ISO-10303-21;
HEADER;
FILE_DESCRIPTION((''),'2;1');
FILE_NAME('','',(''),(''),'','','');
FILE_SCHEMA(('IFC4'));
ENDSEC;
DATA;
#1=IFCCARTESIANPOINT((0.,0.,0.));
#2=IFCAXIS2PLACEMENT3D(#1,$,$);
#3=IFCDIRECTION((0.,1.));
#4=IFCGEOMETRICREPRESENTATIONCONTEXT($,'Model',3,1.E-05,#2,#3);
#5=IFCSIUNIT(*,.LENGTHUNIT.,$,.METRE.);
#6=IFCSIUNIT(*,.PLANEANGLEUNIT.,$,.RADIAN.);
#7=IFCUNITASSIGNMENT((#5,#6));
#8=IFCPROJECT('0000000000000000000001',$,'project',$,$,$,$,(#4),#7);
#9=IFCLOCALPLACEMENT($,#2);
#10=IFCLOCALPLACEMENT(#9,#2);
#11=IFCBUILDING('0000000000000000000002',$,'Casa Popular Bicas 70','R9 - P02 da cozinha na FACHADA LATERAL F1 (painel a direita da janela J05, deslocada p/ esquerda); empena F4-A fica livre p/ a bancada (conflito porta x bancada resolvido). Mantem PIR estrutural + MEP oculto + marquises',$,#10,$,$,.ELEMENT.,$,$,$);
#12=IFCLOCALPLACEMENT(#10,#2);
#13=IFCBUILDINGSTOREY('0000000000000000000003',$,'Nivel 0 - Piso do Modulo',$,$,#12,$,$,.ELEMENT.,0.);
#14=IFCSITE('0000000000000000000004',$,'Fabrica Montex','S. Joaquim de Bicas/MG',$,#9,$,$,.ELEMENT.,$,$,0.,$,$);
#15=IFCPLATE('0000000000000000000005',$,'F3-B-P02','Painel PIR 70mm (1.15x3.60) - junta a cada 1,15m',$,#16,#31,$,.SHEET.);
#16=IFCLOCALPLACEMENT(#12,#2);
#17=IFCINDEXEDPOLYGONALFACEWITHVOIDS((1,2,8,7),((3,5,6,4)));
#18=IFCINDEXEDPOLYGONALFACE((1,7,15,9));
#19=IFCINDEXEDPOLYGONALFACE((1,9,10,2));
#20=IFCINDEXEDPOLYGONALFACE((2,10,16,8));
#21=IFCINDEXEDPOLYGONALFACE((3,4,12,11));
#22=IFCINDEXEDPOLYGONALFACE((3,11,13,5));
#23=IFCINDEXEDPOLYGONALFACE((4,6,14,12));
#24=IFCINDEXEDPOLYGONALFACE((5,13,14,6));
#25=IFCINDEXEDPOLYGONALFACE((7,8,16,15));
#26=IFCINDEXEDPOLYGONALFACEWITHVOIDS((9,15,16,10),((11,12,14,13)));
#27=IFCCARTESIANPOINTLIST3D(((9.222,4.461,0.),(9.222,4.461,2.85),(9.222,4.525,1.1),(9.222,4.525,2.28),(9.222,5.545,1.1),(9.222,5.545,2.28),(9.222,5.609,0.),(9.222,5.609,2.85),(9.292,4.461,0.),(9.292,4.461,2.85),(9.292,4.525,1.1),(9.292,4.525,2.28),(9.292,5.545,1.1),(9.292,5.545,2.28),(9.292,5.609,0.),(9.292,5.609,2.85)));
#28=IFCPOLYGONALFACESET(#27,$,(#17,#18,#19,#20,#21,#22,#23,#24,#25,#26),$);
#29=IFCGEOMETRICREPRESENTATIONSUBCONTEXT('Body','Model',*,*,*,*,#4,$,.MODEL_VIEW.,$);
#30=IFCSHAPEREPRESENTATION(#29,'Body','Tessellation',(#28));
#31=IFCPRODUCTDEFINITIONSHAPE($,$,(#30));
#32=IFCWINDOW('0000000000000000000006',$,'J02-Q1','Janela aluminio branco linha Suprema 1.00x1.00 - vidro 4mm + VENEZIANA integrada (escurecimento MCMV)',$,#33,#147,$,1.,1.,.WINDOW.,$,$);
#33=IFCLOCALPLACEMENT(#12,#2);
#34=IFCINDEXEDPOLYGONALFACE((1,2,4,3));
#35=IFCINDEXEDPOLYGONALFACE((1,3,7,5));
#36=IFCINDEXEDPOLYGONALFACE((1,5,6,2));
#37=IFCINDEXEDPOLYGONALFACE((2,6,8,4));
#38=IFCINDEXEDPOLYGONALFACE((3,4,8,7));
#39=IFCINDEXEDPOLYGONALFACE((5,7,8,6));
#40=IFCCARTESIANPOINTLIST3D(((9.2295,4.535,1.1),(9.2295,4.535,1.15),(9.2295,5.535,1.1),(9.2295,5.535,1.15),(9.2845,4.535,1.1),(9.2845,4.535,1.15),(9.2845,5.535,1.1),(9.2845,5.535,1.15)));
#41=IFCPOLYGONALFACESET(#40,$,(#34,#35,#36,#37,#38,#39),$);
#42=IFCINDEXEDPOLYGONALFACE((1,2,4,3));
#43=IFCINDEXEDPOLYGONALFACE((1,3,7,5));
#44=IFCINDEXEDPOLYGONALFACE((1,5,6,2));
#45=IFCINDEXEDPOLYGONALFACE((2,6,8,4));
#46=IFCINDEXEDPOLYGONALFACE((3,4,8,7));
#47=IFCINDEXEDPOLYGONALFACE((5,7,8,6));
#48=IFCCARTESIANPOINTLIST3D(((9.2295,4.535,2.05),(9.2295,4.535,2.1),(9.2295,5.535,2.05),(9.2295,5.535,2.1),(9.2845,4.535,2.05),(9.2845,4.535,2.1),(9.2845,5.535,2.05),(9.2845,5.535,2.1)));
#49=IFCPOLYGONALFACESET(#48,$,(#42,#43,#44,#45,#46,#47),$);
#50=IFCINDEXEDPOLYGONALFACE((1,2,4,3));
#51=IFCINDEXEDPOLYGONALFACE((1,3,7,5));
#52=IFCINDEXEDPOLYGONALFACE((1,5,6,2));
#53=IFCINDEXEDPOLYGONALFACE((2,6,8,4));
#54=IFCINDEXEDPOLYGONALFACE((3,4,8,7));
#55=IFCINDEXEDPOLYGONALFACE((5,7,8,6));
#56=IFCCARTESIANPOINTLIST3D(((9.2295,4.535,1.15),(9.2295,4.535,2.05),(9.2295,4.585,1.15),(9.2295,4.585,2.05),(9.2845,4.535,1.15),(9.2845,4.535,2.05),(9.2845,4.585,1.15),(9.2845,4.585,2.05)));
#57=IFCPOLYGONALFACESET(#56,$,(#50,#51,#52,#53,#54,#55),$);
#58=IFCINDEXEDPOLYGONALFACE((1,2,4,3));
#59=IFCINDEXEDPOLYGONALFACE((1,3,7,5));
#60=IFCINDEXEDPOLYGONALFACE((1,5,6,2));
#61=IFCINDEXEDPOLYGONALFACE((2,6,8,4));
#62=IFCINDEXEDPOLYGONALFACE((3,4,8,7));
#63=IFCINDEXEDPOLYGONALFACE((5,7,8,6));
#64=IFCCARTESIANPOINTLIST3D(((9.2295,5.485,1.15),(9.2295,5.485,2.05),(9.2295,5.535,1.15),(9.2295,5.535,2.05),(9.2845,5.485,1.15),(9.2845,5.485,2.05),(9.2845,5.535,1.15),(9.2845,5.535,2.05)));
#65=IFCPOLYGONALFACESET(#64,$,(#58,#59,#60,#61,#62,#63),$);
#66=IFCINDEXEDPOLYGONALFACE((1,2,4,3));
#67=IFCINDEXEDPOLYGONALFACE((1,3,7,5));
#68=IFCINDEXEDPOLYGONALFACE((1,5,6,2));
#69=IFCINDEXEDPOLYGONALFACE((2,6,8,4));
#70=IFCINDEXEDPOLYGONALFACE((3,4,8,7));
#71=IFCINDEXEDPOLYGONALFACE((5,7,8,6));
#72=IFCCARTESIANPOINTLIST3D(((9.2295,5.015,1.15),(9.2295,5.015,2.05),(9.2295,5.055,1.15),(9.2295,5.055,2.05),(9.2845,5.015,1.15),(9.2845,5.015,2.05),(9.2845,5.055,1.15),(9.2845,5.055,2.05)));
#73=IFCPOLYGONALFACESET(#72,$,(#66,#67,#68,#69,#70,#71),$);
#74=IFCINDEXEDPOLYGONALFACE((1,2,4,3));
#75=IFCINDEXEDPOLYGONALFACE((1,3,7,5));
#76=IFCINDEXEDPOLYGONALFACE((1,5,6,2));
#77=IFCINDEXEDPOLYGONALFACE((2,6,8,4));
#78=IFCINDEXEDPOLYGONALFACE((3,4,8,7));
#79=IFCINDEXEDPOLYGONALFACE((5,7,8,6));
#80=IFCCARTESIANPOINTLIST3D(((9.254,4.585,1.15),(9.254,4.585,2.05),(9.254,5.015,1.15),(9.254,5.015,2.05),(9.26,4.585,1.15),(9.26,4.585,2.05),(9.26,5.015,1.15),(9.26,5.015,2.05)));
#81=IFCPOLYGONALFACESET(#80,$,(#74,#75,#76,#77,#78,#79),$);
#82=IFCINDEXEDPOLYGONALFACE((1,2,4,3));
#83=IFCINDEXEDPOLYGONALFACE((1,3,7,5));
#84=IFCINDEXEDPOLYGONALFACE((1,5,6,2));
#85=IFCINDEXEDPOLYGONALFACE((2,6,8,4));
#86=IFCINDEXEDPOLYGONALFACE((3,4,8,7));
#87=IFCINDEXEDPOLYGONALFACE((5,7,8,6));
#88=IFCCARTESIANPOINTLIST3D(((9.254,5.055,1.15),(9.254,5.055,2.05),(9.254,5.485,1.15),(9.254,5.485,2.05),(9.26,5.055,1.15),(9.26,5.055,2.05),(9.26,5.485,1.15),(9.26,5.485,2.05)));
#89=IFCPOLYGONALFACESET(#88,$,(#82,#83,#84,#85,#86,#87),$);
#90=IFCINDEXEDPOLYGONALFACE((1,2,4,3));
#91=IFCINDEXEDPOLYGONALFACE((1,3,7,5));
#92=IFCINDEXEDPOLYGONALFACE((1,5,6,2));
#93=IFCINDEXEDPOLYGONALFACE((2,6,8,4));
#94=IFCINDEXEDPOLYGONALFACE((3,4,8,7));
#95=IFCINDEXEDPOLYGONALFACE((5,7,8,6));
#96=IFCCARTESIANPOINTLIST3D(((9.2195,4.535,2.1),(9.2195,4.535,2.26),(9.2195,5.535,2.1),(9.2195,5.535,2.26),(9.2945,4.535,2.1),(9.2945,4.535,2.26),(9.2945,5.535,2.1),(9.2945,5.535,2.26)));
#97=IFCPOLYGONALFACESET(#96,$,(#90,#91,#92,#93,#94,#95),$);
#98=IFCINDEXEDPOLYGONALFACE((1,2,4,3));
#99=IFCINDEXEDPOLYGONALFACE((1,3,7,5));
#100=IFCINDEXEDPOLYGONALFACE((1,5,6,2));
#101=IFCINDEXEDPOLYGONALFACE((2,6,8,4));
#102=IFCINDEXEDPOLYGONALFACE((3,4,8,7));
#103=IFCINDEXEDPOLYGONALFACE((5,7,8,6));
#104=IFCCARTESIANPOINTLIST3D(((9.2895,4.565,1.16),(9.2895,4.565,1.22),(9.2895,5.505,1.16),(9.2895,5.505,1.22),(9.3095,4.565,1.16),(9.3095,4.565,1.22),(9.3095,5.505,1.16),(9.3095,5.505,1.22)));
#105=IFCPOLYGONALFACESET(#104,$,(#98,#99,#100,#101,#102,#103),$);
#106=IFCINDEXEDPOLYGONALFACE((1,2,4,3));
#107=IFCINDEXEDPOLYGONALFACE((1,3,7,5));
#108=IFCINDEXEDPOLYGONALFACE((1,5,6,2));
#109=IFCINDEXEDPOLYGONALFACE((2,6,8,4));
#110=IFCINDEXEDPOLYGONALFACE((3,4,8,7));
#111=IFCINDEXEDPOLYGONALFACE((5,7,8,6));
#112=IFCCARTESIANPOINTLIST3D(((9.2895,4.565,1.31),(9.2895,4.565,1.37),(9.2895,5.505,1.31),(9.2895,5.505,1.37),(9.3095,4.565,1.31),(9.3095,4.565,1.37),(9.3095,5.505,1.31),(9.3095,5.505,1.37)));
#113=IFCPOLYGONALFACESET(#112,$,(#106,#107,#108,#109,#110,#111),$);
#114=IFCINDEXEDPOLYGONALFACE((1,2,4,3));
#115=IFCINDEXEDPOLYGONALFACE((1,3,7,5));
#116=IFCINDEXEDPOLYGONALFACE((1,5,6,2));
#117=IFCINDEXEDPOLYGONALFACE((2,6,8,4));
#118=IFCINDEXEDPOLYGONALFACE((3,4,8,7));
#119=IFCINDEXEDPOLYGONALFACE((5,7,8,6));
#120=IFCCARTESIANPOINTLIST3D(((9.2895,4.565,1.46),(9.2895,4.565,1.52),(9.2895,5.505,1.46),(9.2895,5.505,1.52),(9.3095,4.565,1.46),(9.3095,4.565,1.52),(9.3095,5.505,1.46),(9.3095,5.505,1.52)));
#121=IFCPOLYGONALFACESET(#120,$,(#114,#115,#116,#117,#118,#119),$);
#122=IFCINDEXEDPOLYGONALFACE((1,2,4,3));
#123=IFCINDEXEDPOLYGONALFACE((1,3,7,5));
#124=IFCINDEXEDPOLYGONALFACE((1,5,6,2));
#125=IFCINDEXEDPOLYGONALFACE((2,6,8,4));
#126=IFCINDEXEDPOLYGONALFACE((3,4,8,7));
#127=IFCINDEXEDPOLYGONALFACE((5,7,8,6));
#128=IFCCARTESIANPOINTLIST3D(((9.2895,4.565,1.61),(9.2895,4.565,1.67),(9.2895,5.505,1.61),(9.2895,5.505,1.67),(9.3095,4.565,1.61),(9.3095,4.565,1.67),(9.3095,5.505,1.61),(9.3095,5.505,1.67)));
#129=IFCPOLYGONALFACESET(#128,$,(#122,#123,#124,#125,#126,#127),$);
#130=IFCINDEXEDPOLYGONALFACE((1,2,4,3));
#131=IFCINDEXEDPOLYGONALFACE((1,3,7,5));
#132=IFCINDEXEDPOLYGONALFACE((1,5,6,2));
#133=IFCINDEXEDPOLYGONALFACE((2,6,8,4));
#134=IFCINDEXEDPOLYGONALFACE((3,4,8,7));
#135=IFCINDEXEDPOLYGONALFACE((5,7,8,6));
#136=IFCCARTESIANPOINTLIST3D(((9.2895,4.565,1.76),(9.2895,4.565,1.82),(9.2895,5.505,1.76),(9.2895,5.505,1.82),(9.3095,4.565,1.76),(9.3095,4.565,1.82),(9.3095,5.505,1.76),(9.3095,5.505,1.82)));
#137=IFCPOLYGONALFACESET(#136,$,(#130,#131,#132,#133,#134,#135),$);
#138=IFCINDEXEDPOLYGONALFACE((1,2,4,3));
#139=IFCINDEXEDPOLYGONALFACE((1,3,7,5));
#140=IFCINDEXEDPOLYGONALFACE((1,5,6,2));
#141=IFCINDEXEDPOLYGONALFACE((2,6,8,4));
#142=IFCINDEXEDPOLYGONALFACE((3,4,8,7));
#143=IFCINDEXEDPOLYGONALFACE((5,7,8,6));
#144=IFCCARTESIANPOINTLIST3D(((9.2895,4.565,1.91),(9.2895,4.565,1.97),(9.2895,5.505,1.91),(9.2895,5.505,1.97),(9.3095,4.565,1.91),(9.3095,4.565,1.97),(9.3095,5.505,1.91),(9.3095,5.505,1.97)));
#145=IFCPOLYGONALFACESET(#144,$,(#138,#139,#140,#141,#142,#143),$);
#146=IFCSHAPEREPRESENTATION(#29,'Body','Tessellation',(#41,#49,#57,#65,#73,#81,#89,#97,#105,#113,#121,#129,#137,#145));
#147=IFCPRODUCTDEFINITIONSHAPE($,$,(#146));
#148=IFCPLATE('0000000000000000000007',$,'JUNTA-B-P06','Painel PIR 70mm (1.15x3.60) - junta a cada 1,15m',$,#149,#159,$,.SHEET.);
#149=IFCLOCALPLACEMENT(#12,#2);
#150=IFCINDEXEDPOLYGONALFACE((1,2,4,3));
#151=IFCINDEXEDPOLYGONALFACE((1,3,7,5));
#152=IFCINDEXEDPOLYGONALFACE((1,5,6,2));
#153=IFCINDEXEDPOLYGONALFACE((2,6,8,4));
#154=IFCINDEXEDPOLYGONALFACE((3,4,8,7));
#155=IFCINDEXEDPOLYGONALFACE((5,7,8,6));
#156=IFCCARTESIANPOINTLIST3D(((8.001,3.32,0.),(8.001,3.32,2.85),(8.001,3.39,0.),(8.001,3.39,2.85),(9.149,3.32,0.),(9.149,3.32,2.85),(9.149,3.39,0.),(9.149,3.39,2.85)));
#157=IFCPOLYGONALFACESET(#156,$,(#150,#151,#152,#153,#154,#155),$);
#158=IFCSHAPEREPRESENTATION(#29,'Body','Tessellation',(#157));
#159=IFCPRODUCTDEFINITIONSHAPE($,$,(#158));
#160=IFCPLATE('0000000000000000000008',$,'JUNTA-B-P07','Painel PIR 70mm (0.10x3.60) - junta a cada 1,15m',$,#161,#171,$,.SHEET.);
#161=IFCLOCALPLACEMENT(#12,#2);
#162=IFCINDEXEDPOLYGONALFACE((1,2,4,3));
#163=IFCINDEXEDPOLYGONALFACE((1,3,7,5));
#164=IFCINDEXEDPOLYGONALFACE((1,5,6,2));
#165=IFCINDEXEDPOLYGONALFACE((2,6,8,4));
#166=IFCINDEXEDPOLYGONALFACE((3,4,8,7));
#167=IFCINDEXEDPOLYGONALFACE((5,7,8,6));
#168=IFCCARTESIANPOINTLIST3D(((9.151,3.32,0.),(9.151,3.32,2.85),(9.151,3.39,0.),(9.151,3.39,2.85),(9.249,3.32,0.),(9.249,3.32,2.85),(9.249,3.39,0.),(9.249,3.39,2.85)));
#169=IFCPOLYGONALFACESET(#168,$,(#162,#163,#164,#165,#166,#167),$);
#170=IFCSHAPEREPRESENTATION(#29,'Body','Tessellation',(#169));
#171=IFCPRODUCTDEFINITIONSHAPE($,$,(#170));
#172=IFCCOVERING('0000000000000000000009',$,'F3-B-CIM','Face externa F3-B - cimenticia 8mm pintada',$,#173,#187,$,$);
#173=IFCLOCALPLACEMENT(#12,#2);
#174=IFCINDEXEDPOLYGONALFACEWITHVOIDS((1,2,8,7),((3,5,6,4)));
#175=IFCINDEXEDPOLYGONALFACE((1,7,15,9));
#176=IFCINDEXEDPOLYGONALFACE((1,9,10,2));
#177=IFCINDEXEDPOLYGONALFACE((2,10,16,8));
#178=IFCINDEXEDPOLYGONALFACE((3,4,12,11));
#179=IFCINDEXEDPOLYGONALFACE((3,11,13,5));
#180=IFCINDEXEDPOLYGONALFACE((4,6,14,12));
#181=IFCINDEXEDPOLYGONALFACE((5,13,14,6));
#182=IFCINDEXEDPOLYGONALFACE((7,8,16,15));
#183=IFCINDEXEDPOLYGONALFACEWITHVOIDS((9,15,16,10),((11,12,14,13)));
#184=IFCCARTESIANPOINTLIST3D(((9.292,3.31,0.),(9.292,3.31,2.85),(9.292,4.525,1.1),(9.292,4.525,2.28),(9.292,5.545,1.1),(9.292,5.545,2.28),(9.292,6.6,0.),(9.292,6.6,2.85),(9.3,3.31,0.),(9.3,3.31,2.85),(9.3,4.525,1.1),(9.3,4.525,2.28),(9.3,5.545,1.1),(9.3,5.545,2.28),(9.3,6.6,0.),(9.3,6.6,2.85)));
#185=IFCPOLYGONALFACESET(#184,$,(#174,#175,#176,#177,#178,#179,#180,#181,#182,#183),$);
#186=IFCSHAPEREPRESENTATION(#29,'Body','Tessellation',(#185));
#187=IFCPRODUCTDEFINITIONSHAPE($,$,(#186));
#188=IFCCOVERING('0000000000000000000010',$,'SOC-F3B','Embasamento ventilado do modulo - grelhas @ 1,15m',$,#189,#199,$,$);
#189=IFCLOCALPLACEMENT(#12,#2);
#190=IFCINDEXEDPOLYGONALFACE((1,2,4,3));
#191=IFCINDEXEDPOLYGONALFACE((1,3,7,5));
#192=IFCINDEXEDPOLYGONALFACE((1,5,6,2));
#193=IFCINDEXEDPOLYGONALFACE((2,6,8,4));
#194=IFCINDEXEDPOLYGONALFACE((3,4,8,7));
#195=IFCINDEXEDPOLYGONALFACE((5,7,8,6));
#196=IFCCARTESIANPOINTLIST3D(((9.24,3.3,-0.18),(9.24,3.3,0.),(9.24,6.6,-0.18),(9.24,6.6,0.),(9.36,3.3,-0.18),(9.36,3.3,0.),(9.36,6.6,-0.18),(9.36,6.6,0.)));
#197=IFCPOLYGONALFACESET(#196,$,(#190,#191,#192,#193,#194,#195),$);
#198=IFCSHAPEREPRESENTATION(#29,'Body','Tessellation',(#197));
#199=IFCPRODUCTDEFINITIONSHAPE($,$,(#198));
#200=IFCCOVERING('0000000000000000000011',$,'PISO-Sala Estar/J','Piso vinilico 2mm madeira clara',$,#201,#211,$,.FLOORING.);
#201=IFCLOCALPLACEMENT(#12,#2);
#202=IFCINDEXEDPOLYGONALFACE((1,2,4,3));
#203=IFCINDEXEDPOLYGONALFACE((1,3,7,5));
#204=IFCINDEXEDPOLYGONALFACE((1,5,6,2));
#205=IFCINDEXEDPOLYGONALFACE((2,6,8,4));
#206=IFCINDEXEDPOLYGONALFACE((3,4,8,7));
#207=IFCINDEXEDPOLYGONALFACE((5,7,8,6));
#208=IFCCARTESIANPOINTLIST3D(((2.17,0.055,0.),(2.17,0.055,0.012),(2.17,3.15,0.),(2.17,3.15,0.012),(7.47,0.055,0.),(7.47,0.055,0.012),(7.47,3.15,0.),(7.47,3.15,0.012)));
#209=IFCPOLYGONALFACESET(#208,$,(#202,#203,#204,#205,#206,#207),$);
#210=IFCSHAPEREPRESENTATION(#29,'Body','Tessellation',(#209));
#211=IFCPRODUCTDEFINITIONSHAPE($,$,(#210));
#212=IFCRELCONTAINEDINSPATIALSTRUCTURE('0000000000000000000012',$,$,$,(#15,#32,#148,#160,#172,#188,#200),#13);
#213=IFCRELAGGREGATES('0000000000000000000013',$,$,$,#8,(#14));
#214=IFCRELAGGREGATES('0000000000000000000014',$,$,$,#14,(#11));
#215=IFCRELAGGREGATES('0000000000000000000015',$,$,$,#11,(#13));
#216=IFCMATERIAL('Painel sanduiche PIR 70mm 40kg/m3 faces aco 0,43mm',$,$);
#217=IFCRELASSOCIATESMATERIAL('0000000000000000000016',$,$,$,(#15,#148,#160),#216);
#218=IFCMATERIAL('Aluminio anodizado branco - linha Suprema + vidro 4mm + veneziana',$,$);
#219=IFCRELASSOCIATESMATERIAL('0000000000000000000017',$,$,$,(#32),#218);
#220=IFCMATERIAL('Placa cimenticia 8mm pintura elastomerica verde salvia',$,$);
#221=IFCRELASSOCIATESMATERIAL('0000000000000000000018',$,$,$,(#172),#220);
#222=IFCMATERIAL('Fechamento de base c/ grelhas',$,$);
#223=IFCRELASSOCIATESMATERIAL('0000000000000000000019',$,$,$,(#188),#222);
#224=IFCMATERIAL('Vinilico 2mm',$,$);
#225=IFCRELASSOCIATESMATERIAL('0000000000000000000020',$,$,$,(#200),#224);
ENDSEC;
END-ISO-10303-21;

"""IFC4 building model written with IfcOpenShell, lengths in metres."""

from ifc_helpers import new_model, si_unit, direction, frame, frame_2d, origin, place, context, subcontext, project, spatial, rectangle, extrude, material, element, fill, save


model = new_model("IFC4")

# Units and contexts
model_context = context("Model", 3, precision=1e-05, world=origin(), true_north=direction((0.0, 1.0)))
body_context = subcontext(model_context, "Body", "Model", "MODEL_VIEW")
ifc_project = project(units=[si_unit("LENGTHUNIT", "METRE"), si_unit("PLANEANGLEUNIT", "RADIAN")], contexts=[model_context])

# Site, building, storey
site_placement = place(None, origin())
site = spatial("IfcSite", under=ifc_project, at=site_placement, Name="Fabrica Montex", Description="S. Joaquim de Bicas/MG", CompositionType="ELEMENT", RefElevation=0.0)
building_placement = place(site_placement, origin())
building = spatial("IfcBuilding", under=site, at=building_placement, Name="Casa Popular Bicas 70", Description="R9 - P02 da cozinha na FACHADA LATERAL F1 (painel a direita da janela J05, deslocada p/ esquerda); empena F4-A fica livre p/ a bancada (conflito porta x bancada resolvido). Mantem PIR estrutural + MEP oculto + marquises", CompositionType="ELEMENT")
storey_placement = place(building_placement, origin())
storey = spatial("IfcBuildingStorey", under=building, at=storey_placement, Name="Nivel 0 - Piso do Modulo", CompositionType="ELEMENT", Elevation=0.0)

# Shared definitions
ifc_material_1 = material(Name="Painel sanduiche PIR 70mm 40kg/m3 faces aco 0,43mm")

# Plate, opening, window
plate_1_placement = place(storey_placement, frame((9.257, 4.461, 0.0), x_axis=(0.0, 1.0, 0.0)))
plate_1 = element("IfcPlate", 1, at=plate_1_placement, inside=storey, material=ifc_material_1, Name="F3-B-P02", Description="Painel PIR 70mm (1.15x3.60) - junta a cada 1,15m", PredefinedType="SHEET", context=body_context, shape_type="SweptSolid", body=[
    extrude(rectangle(XDim=1.148, YDim=0.07, at=frame_2d((0.574, 0.0))), origin(), (0.0, 0.0, 1.0), 2.85),
])
opening_1_placement = place(storey_placement, frame((9.257, 4.535, 1.1), x_axis=(0.0, 1.0, 0.0)))
opening_1 = element("IfcOpeningElement", 2, at=opening_1_placement, cuts=plate_1, PredefinedType="OPENING", context=body_context, shape_type="SweptSolid", body=[
    extrude(rectangle(XDim=1.02, YDim=0.3, at=frame_2d((0.5, 0.0))), origin(), (0.0, 0.0, 1.0), 1.18),
])
ifc_material_2 = material(Name="Aluminio anodizado branco - linha Suprema + vidro 4mm + veneziana")
window_placement = place(storey_placement, frame((9.257, 4.535, 1.1), x_axis=(0.0, 1.0, 0.0)))
window = element("IfcWindow", 3, at=window_placement, inside=storey, material=ifc_material_2, Name="J02-Q1", Description="Janela aluminio branco linha Suprema 1.00x1.00 - vidro 4mm + VENEZIANA integrada (escurecimento MCMV)", OverallHeight=1.0, OverallWidth=1.0, PredefinedType="WINDOW", context=body_context, shape_type="SweptSolid", body=[
    extrude(rectangle(XDim=1.0, YDim=0.055, at=frame_2d((0.5, 0.0))), origin(), (0.0, 0.0, 1.0), 0.05),
    extrude(rectangle(XDim=1.0, YDim=0.055, at=frame_2d((0.5, 0.0))), frame((0.0, 0.0, 0.95)), (0.0, 0.0, 1.0), 0.05),
    extrude(rectangle(XDim=0.05, YDim=0.055, at=frame_2d((0.025, 0.0))), frame((0.0, 0.0, 0.05)), (0.0, 0.0, 1.0), 0.9),
    extrude(rectangle(XDim=0.05, YDim=0.055, at=frame_2d((0.975, 0.0))), frame((0.0, 0.0, 0.05)), (0.0, 0.0, 1.0), 0.9),
    extrude(rectangle(XDim=0.04, YDim=0.055, at=frame_2d((0.5, 0.0))), frame((0.0, 0.0, 0.05)), (0.0, 0.0, 1.0), 0.9),
    extrude(rectangle(XDim=0.43, YDim=0.006, at=frame_2d((0.265, 0.0))), frame((0.0, 0.0, 0.05)), (0.0, 0.0, 1.0), 0.9),
    extrude(rectangle(XDim=0.43, YDim=0.006, at=frame_2d((0.735, 0.0))), frame((0.0, 0.0, 0.05)), (0.0, 0.0, 1.0), 0.9),
    extrude(rectangle(XDim=1.0, YDim=0.075, at=frame_2d((0.5, 0.0))), frame((0.0, 0.0, 1.0)), (0.0, 0.0, 1.0), 0.16),
    extrude(rectangle(XDim=0.94, YDim=0.02, at=frame_2d((0.5, -0.0425))), frame((0.0, 0.0, 0.06)), (0.0, 0.0, 1.0), 0.06),
    extrude(rectangle(XDim=0.94, YDim=0.02, at=frame_2d((0.5, -0.0425))), frame((0.0, 0.0, 0.21)), (0.0, 0.0, 1.0), 0.06),
    extrude(rectangle(XDim=0.94, YDim=0.02, at=frame_2d((0.5, -0.0425))), frame((0.0, 0.0, 0.36)), (0.0, 0.0, 1.0), 0.06),
    extrude(rectangle(XDim=0.94, YDim=0.02, at=frame_2d((0.5, -0.0425))), frame((0.0, 0.0, 0.51)), (0.0, 0.0, 1.0), 0.06),
    extrude(rectangle(XDim=0.94, YDim=0.02, at=frame_2d((0.5, -0.0425))), frame((0.0, 0.0, 0.66)), (0.0, 0.0, 1.0), 0.06),
    extrude(rectangle(XDim=0.94, YDim=0.02, at=frame_2d((0.5, -0.0425))), frame((0.0, 0.0, 0.81)), (0.0, 0.0, 1.0), 0.06),
])
fill(opening_1, window)

# Plates
plate_2_placement = place(storey_placement, frame((8.001, 3.355, 0.0), x_axis=(1.0, 0.0, 0.0)))
element("IfcPlate", 4, at=plate_2_placement, inside=storey, material=ifc_material_1, Name="JUNTA-B-P06", Description="Painel PIR 70mm (1.15x3.60) - junta a cada 1,15m", PredefinedType="SHEET", context=body_context, shape_type="SweptSolid", body=[
    extrude(rectangle(XDim=1.148, YDim=0.07, at=frame_2d((0.574, 0.0))), origin(), (0.0, 0.0, 1.0), 2.85),
])
plate_3_placement = place(storey_placement, frame((9.151, 3.355, 0.0), x_axis=(1.0, 0.0, 0.0)))
element("IfcPlate", 5, at=plate_3_placement, inside=storey, material=ifc_material_1, Name="JUNTA-B-P07", Description="Painel PIR 70mm (0.10x3.60) - junta a cada 1,15m", PredefinedType="SHEET", context=body_context, shape_type="SweptSolid", body=[
    extrude(rectangle(XDim=0.098, YDim=0.07, at=frame_2d((0.049, 0.0))), origin(), (0.0, 0.0, 1.0), 2.85),
])

# Covering, opening
ifc_material_3 = material(Name="Placa cimenticia 8mm pintura elastomerica verde salvia")
covering_1_placement = place(storey_placement, frame((9.296, 3.31, 0.0), x_axis=(0.0, 1.0, 0.0)))
covering_1 = element("IfcCovering", 6, at=covering_1_placement, inside=storey, material=ifc_material_3, Name="F3-B-CIM", Description="Face externa F3-B - cimenticia 8mm pintada", context=body_context, shape_type="SweptSolid", body=[
    extrude(rectangle(XDim=3.29, YDim=0.008, at=frame_2d((1.645, 0.0))), origin(), (0.0, 0.0, 1.0), 2.85),
])
opening_2_placement = place(storey_placement, frame((9.296, 4.535, 1.1), x_axis=(0.0, 1.0, 0.0)))
element("IfcOpeningElement", 7, at=opening_2_placement, cuts=covering_1, PredefinedType="OPENING", context=body_context, shape_type="SweptSolid", body=[
    extrude(rectangle(XDim=1.02, YDim=0.03, at=frame_2d((0.5, 0.0))), origin(), (0.0, 0.0, 1.0), 1.18),
])

# Coverings
ifc_material_4 = material(Name="Fechamento de base c/ grelhas")
covering_2_placement = place(storey_placement, frame((9.3, 3.3, -0.18), x_axis=(0.0, 1.0, 0.0)))
element("IfcCovering", 8, at=covering_2_placement, inside=storey, material=ifc_material_4, Name="SOC-F3B", Description="Embasamento ventilado do modulo - grelhas @ 1,15m", context=body_context, shape_type="SweptSolid", body=[
    extrude(rectangle(XDim=3.3, YDim=0.12, at=frame_2d((1.65, 0.0))), origin(), (0.0, 0.0, 1.0), 0.18),
])
ifc_material_5 = material(Name="Vinilico 2mm")
covering_3_placement = place(None, frame((7.47, 3.15, 0.0), z_axis=(0.0, 0.0, 1.0), x_axis=(-1.0, 0.0, 0.0)))
element("IfcCovering", 9, at=covering_3_placement, inside=storey, material=ifc_material_5, Name="PISO-Sala Estar/J", Description="Piso vinilico 2mm madeira clara", PredefinedType="FLOORING", context=body_context, shape_type="SweptSolid", body=[
    extrude(rectangle(XDim=5.3, YDim=3.095, at=frame_2d((2.65, 1.5475))), origin(), (0.0, 0.0, 1.0), 0.012),
])

save(model, "model.ifc")
